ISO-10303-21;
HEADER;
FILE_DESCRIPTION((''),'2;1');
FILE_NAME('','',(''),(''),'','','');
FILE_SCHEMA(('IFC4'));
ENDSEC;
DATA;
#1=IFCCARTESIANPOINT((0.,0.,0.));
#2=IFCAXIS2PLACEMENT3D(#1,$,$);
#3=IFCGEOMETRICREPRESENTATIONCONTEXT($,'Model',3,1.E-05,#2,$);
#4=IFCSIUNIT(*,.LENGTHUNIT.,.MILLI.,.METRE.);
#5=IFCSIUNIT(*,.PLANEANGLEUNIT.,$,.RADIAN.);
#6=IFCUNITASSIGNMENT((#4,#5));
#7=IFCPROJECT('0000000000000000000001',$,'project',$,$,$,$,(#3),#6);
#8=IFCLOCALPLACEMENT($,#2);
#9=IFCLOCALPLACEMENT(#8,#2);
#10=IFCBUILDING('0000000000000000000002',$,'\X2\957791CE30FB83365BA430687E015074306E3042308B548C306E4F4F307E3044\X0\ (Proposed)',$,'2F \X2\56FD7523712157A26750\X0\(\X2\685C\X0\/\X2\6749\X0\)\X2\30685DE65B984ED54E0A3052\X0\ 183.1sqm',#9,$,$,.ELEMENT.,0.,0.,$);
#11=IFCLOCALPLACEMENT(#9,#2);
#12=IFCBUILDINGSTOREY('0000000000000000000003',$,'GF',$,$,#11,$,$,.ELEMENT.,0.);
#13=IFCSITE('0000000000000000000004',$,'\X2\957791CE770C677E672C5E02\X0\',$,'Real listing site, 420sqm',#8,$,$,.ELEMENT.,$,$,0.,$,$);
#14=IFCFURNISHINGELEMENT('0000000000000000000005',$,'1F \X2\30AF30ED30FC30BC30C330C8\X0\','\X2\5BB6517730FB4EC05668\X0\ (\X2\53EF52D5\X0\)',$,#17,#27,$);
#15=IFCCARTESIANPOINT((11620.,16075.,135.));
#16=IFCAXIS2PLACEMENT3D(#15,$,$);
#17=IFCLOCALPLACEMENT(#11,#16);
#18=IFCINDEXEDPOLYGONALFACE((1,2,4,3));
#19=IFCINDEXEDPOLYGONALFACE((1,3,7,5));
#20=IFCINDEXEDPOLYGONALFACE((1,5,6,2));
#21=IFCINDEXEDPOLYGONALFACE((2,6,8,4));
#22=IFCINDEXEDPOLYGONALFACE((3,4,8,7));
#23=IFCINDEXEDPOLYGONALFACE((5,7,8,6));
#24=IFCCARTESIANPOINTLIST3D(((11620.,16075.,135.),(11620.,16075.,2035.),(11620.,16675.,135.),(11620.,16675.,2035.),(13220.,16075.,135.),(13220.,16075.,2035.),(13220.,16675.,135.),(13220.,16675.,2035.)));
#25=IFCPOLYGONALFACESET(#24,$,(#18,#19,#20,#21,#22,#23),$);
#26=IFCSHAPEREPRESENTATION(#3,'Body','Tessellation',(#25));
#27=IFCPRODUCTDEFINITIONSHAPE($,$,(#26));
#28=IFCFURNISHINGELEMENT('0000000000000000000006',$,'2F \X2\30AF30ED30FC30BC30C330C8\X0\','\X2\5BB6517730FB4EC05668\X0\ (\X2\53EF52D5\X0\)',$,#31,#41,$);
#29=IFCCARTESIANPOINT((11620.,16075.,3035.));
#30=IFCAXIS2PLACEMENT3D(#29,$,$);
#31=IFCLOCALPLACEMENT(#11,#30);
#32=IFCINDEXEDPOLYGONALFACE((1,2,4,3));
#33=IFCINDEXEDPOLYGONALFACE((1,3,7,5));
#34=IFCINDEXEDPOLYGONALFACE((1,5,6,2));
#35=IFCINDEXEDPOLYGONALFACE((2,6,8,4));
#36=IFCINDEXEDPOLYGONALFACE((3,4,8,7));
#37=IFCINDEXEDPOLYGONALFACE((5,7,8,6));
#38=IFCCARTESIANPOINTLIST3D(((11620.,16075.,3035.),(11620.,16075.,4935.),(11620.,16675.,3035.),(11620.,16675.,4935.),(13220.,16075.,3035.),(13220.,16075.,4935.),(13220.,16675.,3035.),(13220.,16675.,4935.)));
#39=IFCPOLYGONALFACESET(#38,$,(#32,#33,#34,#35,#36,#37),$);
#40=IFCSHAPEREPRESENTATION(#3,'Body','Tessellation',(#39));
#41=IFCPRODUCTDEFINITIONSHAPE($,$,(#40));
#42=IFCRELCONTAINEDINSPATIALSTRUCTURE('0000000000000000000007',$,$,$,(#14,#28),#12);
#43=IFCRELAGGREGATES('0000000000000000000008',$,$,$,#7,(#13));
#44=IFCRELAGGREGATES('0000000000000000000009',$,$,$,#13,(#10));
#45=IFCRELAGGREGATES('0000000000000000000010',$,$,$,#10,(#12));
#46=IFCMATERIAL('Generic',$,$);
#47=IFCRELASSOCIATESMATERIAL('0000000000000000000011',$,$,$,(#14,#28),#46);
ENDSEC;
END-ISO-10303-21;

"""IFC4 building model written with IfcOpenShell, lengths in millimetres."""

from ifc_helpers import new_model, si_unit, frame, frame_2d, origin, place, context, project, spatial, rectangle, extrude, material, element, save


model = new_model("IFC4")

# Units and contexts
model_context = context("Model", 3, precision=1e-05, world=origin())
ifc_project = project(units=[si_unit("LENGTHUNIT", "METRE", prefix="MILLI"), si_unit("PLANEANGLEUNIT", "RADIAN")], contexts=[model_context])

# Site, building, storey
site_placement = place(None, origin())
site = spatial("IfcSite", under=ifc_project, at=site_placement, Name="長野県松本市", ObjectType="Real listing site, 420sqm", CompositionType="ELEMENT", RefElevation=0.0)
building_placement = place(site_placement, origin())
building = spatial("IfcBuilding", under=site, at=building_placement, Name="長野・茶室と縁側のある和の住まい (Proposed)", ObjectType="2F 国産無垢材(桜/杉)と左官仕上げ 183.1sqm", CompositionType="ELEMENT", ElevationOfRefHeight=0.0, ElevationOfTerrain=0.0)
storey_placement = place(building_placement, origin())
storey = spatial("IfcBuildingStorey", under=building, at=storey_placement, Name="GF", CompositionType="ELEMENT", Elevation=0.0)

# Shared definitions
ifc_material_1 = material(Name="Generic")

# Furnishing elements
furnishing_1_placement = place(storey_placement, frame((11620.0, 16075.0, 135.0)))
element("IfcFurnishingElement", 1, at=furnishing_1_placement, inside=storey, material=ifc_material_1, Name="1F クローゼット", Description="家具・什器 (可動)", context=model_context, shape_type="SweptSolid", body=[
    extrude(rectangle(XDim=1600.0, YDim=600.0, at=frame_2d((800.0, 300.0))), frame((11620.0, 16075.0, 135.0)), (0.0, 0.0, 1.0), 1900.0),
])
furnishing_2_placement = place(storey_placement, frame((11620.0, 16075.0, 3035.0)))
element("IfcFurnishingElement", 2, at=furnishing_2_placement, inside=storey, material=ifc_material_1, Name="2F クローゼット", Description="家具・什器 (可動)", context=model_context, shape_type="SweptSolid", body=[
    extrude(rectangle(XDim=1600.0, YDim=600.0, at=frame_2d((800.0, 300.0))), frame((11620.0, 16075.0, 3035.0)), (0.0, 0.0, 1.0), 1900.0),
])

save(model, "model.ifc")
